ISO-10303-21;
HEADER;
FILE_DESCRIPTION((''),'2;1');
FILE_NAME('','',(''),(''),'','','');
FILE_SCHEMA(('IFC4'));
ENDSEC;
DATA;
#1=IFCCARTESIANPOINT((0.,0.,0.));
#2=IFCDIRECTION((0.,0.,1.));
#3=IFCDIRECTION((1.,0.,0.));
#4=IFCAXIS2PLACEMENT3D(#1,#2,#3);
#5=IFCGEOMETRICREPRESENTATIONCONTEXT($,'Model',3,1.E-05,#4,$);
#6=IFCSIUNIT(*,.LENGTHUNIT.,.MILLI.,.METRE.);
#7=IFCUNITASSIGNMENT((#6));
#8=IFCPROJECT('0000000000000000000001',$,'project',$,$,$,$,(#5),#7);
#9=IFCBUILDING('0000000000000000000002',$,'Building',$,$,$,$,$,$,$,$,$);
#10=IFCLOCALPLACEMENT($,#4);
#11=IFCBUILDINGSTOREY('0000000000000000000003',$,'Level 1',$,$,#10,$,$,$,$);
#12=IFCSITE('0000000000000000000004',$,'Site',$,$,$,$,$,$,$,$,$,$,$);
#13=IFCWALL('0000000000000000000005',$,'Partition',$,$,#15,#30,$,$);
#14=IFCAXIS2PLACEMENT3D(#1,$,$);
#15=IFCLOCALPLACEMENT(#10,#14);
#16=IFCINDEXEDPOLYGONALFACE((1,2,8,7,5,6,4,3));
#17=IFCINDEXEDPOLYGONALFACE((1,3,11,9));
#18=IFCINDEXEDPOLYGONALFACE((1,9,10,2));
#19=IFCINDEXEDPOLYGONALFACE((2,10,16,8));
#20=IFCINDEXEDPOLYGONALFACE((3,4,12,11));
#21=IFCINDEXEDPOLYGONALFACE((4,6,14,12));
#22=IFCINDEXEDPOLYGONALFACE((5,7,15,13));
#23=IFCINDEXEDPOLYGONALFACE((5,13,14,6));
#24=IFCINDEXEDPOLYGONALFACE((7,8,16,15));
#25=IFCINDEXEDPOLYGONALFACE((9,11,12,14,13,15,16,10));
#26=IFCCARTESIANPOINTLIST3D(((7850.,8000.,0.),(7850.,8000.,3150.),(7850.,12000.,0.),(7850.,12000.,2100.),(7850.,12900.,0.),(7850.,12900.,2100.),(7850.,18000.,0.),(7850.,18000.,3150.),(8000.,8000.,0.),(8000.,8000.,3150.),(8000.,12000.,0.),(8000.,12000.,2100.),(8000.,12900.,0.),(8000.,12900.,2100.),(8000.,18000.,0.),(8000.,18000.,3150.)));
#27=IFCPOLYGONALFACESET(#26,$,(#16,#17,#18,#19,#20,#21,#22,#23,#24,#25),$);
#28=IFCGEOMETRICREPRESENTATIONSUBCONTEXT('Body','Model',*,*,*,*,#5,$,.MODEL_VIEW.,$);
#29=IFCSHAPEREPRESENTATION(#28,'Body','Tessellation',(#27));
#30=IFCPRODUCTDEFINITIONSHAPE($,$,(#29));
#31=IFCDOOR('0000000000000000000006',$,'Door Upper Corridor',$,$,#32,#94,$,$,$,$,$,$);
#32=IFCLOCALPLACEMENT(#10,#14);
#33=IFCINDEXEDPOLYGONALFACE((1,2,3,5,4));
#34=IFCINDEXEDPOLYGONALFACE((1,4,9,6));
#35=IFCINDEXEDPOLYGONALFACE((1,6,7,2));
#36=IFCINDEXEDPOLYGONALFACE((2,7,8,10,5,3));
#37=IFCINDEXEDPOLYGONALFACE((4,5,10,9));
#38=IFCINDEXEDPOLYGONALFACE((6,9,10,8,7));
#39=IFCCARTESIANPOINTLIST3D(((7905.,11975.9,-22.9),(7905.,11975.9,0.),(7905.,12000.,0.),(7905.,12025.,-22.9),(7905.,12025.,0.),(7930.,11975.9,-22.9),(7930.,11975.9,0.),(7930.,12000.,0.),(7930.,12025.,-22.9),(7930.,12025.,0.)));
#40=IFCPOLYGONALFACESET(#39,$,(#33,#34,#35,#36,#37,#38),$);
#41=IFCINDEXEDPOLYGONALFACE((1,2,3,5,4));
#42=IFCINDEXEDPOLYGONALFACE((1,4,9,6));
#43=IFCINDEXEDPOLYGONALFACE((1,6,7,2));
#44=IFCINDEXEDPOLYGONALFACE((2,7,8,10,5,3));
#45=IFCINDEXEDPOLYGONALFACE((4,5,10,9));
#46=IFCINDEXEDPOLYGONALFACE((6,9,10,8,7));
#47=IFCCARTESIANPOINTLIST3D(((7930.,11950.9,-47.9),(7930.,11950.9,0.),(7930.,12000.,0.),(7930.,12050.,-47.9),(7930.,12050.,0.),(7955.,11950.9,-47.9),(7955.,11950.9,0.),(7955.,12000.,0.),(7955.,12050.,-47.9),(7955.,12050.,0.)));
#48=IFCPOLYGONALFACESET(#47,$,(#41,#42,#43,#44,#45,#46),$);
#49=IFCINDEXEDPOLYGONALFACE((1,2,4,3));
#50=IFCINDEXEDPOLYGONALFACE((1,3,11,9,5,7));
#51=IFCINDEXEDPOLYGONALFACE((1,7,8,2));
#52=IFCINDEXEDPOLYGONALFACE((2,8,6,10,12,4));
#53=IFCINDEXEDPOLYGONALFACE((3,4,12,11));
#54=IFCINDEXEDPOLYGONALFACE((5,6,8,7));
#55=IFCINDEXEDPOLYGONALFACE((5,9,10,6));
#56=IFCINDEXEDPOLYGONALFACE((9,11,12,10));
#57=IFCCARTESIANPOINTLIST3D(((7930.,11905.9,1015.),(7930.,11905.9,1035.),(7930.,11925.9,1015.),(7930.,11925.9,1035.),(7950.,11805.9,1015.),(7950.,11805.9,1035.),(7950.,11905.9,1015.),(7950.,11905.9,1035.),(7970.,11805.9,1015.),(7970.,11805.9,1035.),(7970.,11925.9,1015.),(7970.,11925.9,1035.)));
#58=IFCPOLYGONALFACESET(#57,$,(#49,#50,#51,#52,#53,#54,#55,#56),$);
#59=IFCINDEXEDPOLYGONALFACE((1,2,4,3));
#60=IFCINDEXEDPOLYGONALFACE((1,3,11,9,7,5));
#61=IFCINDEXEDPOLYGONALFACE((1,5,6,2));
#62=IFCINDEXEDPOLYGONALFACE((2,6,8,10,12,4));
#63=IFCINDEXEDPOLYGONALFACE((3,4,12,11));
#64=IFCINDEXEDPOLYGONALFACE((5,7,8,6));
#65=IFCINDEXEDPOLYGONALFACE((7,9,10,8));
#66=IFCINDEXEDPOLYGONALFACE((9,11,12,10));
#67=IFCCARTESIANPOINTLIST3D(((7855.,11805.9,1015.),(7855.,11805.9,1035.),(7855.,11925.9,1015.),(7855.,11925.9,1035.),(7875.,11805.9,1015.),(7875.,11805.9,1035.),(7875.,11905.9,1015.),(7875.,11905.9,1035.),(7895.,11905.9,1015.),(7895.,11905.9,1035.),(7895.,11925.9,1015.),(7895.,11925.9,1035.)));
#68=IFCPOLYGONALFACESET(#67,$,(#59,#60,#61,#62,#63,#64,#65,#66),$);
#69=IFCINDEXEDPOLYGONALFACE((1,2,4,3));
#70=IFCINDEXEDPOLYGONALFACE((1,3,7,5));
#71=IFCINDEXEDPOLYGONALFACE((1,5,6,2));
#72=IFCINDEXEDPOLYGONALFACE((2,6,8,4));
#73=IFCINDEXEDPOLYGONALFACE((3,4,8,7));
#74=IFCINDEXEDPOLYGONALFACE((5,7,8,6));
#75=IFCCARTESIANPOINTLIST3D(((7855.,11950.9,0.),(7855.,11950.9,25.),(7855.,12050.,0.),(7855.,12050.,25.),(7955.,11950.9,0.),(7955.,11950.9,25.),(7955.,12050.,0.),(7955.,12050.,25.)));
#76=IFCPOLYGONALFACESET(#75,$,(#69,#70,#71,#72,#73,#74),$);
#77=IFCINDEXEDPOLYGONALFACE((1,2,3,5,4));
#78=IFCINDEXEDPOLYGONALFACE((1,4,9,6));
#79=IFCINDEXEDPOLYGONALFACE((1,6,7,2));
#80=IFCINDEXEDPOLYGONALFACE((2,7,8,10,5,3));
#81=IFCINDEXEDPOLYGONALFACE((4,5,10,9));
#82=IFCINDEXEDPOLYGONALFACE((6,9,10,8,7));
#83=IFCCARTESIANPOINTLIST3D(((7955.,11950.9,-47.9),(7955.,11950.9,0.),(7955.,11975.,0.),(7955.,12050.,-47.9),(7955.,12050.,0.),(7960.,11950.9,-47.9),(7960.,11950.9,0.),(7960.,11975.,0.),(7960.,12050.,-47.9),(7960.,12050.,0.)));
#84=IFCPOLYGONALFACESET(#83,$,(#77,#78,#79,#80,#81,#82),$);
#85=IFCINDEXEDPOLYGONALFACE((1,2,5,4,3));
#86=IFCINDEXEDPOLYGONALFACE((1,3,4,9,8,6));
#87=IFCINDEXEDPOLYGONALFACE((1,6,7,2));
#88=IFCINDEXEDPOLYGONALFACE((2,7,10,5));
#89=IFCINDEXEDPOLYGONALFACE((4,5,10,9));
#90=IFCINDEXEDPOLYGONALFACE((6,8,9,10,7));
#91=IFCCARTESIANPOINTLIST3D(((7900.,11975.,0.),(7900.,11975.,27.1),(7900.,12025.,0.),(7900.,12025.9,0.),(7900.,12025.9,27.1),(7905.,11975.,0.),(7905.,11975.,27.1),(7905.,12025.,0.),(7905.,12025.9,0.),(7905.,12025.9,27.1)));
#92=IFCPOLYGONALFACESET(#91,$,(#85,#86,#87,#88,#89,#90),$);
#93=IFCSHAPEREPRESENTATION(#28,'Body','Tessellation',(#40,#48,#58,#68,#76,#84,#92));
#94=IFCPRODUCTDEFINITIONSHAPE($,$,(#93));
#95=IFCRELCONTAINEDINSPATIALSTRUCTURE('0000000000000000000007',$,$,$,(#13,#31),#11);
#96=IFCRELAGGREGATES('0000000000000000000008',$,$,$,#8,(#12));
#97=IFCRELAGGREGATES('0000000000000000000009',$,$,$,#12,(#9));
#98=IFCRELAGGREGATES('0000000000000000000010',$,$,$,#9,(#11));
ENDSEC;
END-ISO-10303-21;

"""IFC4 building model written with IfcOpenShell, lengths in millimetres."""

from ifc_helpers import new_model, si_unit, frame, origin_with_axes, place, context, subcontext, project, spatial, line, indexed_curve, outline, extrude, element, fill, save


model = new_model("IFC4")

# Units and contexts
model_context = context("Model", 3, precision=1e-05, world=origin_with_axes())
body_context = subcontext(model_context, "Body", "Model", "MODEL_VIEW")
ifc_project = project(units=[si_unit("LENGTHUNIT", "METRE", prefix="MILLI")], contexts=[model_context])

# Site, building, storey
site = spatial("IfcSite", under=ifc_project, Name="Site")
building = spatial("IfcBuilding", under=site, Name="Building")
storey_placement = place(None, origin_with_axes())
storey = spatial("IfcBuildingStorey", under=building, at=storey_placement, Name="Level 1")

# Wall, opening, door
wall_1_placement = place(storey_placement, frame((8000.0, 8000.0, 0.0), z_axis=(0.0, 0.0, 1.0), x_axis=(0.0, 1.0, 0.0)))
wall_1 = element("IfcWall", 1, at=wall_1_placement, inside=storey, Name="Partition", context=body_context, shape_type="SweptSolid", body=[
    extrude(outline(indexed_curve([(0.0, 0.0), (0.0, 150.0), (10000.0, 150.0), (10000.0, 0.0), (0.0, 0.0)], self_intersect=False)), origin_with_axes(), (0.0, 0.0, 1.0), 3150.0),
])
opening_1_placement = place(wall_1_placement, frame((4000.0, -100.0, 0.0), z_axis=(0.0, 0.0, 1.0), x_axis=(1.0, 0.0, 0.0)))
opening_1 = element("IfcOpeningElement", 2, at=opening_1_placement, cuts=wall_1, context=body_context, shape_type="SweptSolid", body=[
    extrude(outline(indexed_curve([(0.0, 0.0), (0.0, 350.0), (900.0, 350.0), (900.0, 0.0), (0.0, 0.0)], self_intersect=False)), origin_with_axes(), (0.0, 0.0, 1.0), 2100.0),
])
door_1_placement = place(opening_1_placement, frame((0.0, 145.0, 0.0), z_axis=(0.0, 0.0, 1.0), x_axis=(1.0, 0.0, 0.0)))
door_1 = element("IfcDoor", 3, at=door_1_placement, inside=storey, Name="Door Upper Corridor", context=body_context, shape_type="SweptSolid", body=[
    extrude(outline(indexed_curve([(0.0, 0.0), (0.0, 2.1), (0.9, 2.1), (0.9, 0.0), (-24.1, 0.0), (-24.1, -22.9), (25.0, -22.9), (25.0, 0.0)], segments=[line(1, 2, 3, 4, 5, 6, 7, 8, 1)])), frame((0.0, 25.0, 0.0), z_axis=(0.0, -1.0, 0.0), x_axis=(1.0, 0.0, 0.0)), (0.0, 0.0, -1.0), 25.0),
    extrude(outline(indexed_curve([(0.0, 0.0), (0.0, 2.1), (0.9, 2.1), (0.9, 0.0), (-49.1, 0.0), (-49.1, -47.9), (50.0, -47.9), (50.0, 0.0)], segments=[line(1, 2, 3, 4, 5, 6, 7, 8, 1)])), frame((0.0, 0.0, 0.0), z_axis=(0.0, -1.0, 0.0), x_axis=(1.0, 0.0, 0.0)), (0.0, 0.0, -1.0), 25.0),
    extrude(outline(indexed_curve([(0.0, 0.0), (-49.1, 0.0), (-49.1, 35.0), (0.0, 35.0)], segments=[line(1, 2, 3, 4, 1)])), frame((25.0, 25.0, 25.0), z_axis=(0.0, 0.0, 1.0), x_axis=(1.0, 0.0, 0.0)), (0.0, 0.0, 1.0), -47.9),
    extrude(outline(indexed_curve([(0.0, 0.0), (0.0, -40.0), (-120.0, -40.0), (-120.0, -20.0), (-20.0, -20.0), (-20.0, 0.0)], segments=[line(1, 2, 3, 4, 5, 6, 1)])), frame((-74.1, 25.0, 1015.0), z_axis=(0.0, 0.0, 1.0), x_axis=(1.0, 0.0, 0.0)), (0.0, 0.0, 1.0), 20.0),
    extrude(outline(indexed_curve([(0.0, 0.0), (0.0, 40.0), (-120.0, 40.0), (-120.0, 20.0), (-20.0, 20.0), (-20.0, 0.0)], segments=[line(1, 2, 3, 4, 5, 6, 1)])), frame((-74.1, 60.0, 1015.0), z_axis=(0.0, 0.0, 1.0), x_axis=(1.0, 0.0, 0.0)), (0.0, 0.0, 1.0), 20.0),
    extrude(outline(indexed_curve([(0.0, 0.0), (-99.1, 0.0), (-99.1, 100.0), (0.0, 100.0)], segments=[line(1, 2, 3, 4, 1)])), frame((50.0, 0.0, 0.0), z_axis=(0.0, 0.0, 1.0), x_axis=(1.0, 0.0, 0.0)), (0.0, 0.0, 1.0), 25.0),
    extrude(outline(indexed_curve([(0.0, 0.0), (0.0, 27.1), (50.9, 27.1), (50.9, 0.0), (-24.1, 0.0), (-24.1, -47.9), (75.0, -47.9), (75.0, 0.0)], segments=[line(1, 2, 3, 4, 5, 6, 7, 8, 1)])), frame((-25.0, -5.0, 0.0), z_axis=(0.0, -1.0, 0.0), x_axis=(1.0, 0.0, 0.0)), (0.0, 0.0, -1.0), 5.0),
    extrude(outline(indexed_curve([(0.0, 0.0), (0.0, 27.1), (50.9, 27.1), (50.9, 0.0), (0.9, 0.0), (0.9, -22.9), (50.0, -22.9), (50.0, 0.0)], segments=[line(1, 2, 3, 4, 5, 6, 7, 8, 1)])), frame((-25.0, 50.0, 0.0), z_axis=(0.0, -1.0, 0.0), x_axis=(1.0, 0.0, 0.0)), (0.0, 0.0, -1.0), 5.0),
])
fill(opening_1, door_1)

save(model, "model.ifc")
